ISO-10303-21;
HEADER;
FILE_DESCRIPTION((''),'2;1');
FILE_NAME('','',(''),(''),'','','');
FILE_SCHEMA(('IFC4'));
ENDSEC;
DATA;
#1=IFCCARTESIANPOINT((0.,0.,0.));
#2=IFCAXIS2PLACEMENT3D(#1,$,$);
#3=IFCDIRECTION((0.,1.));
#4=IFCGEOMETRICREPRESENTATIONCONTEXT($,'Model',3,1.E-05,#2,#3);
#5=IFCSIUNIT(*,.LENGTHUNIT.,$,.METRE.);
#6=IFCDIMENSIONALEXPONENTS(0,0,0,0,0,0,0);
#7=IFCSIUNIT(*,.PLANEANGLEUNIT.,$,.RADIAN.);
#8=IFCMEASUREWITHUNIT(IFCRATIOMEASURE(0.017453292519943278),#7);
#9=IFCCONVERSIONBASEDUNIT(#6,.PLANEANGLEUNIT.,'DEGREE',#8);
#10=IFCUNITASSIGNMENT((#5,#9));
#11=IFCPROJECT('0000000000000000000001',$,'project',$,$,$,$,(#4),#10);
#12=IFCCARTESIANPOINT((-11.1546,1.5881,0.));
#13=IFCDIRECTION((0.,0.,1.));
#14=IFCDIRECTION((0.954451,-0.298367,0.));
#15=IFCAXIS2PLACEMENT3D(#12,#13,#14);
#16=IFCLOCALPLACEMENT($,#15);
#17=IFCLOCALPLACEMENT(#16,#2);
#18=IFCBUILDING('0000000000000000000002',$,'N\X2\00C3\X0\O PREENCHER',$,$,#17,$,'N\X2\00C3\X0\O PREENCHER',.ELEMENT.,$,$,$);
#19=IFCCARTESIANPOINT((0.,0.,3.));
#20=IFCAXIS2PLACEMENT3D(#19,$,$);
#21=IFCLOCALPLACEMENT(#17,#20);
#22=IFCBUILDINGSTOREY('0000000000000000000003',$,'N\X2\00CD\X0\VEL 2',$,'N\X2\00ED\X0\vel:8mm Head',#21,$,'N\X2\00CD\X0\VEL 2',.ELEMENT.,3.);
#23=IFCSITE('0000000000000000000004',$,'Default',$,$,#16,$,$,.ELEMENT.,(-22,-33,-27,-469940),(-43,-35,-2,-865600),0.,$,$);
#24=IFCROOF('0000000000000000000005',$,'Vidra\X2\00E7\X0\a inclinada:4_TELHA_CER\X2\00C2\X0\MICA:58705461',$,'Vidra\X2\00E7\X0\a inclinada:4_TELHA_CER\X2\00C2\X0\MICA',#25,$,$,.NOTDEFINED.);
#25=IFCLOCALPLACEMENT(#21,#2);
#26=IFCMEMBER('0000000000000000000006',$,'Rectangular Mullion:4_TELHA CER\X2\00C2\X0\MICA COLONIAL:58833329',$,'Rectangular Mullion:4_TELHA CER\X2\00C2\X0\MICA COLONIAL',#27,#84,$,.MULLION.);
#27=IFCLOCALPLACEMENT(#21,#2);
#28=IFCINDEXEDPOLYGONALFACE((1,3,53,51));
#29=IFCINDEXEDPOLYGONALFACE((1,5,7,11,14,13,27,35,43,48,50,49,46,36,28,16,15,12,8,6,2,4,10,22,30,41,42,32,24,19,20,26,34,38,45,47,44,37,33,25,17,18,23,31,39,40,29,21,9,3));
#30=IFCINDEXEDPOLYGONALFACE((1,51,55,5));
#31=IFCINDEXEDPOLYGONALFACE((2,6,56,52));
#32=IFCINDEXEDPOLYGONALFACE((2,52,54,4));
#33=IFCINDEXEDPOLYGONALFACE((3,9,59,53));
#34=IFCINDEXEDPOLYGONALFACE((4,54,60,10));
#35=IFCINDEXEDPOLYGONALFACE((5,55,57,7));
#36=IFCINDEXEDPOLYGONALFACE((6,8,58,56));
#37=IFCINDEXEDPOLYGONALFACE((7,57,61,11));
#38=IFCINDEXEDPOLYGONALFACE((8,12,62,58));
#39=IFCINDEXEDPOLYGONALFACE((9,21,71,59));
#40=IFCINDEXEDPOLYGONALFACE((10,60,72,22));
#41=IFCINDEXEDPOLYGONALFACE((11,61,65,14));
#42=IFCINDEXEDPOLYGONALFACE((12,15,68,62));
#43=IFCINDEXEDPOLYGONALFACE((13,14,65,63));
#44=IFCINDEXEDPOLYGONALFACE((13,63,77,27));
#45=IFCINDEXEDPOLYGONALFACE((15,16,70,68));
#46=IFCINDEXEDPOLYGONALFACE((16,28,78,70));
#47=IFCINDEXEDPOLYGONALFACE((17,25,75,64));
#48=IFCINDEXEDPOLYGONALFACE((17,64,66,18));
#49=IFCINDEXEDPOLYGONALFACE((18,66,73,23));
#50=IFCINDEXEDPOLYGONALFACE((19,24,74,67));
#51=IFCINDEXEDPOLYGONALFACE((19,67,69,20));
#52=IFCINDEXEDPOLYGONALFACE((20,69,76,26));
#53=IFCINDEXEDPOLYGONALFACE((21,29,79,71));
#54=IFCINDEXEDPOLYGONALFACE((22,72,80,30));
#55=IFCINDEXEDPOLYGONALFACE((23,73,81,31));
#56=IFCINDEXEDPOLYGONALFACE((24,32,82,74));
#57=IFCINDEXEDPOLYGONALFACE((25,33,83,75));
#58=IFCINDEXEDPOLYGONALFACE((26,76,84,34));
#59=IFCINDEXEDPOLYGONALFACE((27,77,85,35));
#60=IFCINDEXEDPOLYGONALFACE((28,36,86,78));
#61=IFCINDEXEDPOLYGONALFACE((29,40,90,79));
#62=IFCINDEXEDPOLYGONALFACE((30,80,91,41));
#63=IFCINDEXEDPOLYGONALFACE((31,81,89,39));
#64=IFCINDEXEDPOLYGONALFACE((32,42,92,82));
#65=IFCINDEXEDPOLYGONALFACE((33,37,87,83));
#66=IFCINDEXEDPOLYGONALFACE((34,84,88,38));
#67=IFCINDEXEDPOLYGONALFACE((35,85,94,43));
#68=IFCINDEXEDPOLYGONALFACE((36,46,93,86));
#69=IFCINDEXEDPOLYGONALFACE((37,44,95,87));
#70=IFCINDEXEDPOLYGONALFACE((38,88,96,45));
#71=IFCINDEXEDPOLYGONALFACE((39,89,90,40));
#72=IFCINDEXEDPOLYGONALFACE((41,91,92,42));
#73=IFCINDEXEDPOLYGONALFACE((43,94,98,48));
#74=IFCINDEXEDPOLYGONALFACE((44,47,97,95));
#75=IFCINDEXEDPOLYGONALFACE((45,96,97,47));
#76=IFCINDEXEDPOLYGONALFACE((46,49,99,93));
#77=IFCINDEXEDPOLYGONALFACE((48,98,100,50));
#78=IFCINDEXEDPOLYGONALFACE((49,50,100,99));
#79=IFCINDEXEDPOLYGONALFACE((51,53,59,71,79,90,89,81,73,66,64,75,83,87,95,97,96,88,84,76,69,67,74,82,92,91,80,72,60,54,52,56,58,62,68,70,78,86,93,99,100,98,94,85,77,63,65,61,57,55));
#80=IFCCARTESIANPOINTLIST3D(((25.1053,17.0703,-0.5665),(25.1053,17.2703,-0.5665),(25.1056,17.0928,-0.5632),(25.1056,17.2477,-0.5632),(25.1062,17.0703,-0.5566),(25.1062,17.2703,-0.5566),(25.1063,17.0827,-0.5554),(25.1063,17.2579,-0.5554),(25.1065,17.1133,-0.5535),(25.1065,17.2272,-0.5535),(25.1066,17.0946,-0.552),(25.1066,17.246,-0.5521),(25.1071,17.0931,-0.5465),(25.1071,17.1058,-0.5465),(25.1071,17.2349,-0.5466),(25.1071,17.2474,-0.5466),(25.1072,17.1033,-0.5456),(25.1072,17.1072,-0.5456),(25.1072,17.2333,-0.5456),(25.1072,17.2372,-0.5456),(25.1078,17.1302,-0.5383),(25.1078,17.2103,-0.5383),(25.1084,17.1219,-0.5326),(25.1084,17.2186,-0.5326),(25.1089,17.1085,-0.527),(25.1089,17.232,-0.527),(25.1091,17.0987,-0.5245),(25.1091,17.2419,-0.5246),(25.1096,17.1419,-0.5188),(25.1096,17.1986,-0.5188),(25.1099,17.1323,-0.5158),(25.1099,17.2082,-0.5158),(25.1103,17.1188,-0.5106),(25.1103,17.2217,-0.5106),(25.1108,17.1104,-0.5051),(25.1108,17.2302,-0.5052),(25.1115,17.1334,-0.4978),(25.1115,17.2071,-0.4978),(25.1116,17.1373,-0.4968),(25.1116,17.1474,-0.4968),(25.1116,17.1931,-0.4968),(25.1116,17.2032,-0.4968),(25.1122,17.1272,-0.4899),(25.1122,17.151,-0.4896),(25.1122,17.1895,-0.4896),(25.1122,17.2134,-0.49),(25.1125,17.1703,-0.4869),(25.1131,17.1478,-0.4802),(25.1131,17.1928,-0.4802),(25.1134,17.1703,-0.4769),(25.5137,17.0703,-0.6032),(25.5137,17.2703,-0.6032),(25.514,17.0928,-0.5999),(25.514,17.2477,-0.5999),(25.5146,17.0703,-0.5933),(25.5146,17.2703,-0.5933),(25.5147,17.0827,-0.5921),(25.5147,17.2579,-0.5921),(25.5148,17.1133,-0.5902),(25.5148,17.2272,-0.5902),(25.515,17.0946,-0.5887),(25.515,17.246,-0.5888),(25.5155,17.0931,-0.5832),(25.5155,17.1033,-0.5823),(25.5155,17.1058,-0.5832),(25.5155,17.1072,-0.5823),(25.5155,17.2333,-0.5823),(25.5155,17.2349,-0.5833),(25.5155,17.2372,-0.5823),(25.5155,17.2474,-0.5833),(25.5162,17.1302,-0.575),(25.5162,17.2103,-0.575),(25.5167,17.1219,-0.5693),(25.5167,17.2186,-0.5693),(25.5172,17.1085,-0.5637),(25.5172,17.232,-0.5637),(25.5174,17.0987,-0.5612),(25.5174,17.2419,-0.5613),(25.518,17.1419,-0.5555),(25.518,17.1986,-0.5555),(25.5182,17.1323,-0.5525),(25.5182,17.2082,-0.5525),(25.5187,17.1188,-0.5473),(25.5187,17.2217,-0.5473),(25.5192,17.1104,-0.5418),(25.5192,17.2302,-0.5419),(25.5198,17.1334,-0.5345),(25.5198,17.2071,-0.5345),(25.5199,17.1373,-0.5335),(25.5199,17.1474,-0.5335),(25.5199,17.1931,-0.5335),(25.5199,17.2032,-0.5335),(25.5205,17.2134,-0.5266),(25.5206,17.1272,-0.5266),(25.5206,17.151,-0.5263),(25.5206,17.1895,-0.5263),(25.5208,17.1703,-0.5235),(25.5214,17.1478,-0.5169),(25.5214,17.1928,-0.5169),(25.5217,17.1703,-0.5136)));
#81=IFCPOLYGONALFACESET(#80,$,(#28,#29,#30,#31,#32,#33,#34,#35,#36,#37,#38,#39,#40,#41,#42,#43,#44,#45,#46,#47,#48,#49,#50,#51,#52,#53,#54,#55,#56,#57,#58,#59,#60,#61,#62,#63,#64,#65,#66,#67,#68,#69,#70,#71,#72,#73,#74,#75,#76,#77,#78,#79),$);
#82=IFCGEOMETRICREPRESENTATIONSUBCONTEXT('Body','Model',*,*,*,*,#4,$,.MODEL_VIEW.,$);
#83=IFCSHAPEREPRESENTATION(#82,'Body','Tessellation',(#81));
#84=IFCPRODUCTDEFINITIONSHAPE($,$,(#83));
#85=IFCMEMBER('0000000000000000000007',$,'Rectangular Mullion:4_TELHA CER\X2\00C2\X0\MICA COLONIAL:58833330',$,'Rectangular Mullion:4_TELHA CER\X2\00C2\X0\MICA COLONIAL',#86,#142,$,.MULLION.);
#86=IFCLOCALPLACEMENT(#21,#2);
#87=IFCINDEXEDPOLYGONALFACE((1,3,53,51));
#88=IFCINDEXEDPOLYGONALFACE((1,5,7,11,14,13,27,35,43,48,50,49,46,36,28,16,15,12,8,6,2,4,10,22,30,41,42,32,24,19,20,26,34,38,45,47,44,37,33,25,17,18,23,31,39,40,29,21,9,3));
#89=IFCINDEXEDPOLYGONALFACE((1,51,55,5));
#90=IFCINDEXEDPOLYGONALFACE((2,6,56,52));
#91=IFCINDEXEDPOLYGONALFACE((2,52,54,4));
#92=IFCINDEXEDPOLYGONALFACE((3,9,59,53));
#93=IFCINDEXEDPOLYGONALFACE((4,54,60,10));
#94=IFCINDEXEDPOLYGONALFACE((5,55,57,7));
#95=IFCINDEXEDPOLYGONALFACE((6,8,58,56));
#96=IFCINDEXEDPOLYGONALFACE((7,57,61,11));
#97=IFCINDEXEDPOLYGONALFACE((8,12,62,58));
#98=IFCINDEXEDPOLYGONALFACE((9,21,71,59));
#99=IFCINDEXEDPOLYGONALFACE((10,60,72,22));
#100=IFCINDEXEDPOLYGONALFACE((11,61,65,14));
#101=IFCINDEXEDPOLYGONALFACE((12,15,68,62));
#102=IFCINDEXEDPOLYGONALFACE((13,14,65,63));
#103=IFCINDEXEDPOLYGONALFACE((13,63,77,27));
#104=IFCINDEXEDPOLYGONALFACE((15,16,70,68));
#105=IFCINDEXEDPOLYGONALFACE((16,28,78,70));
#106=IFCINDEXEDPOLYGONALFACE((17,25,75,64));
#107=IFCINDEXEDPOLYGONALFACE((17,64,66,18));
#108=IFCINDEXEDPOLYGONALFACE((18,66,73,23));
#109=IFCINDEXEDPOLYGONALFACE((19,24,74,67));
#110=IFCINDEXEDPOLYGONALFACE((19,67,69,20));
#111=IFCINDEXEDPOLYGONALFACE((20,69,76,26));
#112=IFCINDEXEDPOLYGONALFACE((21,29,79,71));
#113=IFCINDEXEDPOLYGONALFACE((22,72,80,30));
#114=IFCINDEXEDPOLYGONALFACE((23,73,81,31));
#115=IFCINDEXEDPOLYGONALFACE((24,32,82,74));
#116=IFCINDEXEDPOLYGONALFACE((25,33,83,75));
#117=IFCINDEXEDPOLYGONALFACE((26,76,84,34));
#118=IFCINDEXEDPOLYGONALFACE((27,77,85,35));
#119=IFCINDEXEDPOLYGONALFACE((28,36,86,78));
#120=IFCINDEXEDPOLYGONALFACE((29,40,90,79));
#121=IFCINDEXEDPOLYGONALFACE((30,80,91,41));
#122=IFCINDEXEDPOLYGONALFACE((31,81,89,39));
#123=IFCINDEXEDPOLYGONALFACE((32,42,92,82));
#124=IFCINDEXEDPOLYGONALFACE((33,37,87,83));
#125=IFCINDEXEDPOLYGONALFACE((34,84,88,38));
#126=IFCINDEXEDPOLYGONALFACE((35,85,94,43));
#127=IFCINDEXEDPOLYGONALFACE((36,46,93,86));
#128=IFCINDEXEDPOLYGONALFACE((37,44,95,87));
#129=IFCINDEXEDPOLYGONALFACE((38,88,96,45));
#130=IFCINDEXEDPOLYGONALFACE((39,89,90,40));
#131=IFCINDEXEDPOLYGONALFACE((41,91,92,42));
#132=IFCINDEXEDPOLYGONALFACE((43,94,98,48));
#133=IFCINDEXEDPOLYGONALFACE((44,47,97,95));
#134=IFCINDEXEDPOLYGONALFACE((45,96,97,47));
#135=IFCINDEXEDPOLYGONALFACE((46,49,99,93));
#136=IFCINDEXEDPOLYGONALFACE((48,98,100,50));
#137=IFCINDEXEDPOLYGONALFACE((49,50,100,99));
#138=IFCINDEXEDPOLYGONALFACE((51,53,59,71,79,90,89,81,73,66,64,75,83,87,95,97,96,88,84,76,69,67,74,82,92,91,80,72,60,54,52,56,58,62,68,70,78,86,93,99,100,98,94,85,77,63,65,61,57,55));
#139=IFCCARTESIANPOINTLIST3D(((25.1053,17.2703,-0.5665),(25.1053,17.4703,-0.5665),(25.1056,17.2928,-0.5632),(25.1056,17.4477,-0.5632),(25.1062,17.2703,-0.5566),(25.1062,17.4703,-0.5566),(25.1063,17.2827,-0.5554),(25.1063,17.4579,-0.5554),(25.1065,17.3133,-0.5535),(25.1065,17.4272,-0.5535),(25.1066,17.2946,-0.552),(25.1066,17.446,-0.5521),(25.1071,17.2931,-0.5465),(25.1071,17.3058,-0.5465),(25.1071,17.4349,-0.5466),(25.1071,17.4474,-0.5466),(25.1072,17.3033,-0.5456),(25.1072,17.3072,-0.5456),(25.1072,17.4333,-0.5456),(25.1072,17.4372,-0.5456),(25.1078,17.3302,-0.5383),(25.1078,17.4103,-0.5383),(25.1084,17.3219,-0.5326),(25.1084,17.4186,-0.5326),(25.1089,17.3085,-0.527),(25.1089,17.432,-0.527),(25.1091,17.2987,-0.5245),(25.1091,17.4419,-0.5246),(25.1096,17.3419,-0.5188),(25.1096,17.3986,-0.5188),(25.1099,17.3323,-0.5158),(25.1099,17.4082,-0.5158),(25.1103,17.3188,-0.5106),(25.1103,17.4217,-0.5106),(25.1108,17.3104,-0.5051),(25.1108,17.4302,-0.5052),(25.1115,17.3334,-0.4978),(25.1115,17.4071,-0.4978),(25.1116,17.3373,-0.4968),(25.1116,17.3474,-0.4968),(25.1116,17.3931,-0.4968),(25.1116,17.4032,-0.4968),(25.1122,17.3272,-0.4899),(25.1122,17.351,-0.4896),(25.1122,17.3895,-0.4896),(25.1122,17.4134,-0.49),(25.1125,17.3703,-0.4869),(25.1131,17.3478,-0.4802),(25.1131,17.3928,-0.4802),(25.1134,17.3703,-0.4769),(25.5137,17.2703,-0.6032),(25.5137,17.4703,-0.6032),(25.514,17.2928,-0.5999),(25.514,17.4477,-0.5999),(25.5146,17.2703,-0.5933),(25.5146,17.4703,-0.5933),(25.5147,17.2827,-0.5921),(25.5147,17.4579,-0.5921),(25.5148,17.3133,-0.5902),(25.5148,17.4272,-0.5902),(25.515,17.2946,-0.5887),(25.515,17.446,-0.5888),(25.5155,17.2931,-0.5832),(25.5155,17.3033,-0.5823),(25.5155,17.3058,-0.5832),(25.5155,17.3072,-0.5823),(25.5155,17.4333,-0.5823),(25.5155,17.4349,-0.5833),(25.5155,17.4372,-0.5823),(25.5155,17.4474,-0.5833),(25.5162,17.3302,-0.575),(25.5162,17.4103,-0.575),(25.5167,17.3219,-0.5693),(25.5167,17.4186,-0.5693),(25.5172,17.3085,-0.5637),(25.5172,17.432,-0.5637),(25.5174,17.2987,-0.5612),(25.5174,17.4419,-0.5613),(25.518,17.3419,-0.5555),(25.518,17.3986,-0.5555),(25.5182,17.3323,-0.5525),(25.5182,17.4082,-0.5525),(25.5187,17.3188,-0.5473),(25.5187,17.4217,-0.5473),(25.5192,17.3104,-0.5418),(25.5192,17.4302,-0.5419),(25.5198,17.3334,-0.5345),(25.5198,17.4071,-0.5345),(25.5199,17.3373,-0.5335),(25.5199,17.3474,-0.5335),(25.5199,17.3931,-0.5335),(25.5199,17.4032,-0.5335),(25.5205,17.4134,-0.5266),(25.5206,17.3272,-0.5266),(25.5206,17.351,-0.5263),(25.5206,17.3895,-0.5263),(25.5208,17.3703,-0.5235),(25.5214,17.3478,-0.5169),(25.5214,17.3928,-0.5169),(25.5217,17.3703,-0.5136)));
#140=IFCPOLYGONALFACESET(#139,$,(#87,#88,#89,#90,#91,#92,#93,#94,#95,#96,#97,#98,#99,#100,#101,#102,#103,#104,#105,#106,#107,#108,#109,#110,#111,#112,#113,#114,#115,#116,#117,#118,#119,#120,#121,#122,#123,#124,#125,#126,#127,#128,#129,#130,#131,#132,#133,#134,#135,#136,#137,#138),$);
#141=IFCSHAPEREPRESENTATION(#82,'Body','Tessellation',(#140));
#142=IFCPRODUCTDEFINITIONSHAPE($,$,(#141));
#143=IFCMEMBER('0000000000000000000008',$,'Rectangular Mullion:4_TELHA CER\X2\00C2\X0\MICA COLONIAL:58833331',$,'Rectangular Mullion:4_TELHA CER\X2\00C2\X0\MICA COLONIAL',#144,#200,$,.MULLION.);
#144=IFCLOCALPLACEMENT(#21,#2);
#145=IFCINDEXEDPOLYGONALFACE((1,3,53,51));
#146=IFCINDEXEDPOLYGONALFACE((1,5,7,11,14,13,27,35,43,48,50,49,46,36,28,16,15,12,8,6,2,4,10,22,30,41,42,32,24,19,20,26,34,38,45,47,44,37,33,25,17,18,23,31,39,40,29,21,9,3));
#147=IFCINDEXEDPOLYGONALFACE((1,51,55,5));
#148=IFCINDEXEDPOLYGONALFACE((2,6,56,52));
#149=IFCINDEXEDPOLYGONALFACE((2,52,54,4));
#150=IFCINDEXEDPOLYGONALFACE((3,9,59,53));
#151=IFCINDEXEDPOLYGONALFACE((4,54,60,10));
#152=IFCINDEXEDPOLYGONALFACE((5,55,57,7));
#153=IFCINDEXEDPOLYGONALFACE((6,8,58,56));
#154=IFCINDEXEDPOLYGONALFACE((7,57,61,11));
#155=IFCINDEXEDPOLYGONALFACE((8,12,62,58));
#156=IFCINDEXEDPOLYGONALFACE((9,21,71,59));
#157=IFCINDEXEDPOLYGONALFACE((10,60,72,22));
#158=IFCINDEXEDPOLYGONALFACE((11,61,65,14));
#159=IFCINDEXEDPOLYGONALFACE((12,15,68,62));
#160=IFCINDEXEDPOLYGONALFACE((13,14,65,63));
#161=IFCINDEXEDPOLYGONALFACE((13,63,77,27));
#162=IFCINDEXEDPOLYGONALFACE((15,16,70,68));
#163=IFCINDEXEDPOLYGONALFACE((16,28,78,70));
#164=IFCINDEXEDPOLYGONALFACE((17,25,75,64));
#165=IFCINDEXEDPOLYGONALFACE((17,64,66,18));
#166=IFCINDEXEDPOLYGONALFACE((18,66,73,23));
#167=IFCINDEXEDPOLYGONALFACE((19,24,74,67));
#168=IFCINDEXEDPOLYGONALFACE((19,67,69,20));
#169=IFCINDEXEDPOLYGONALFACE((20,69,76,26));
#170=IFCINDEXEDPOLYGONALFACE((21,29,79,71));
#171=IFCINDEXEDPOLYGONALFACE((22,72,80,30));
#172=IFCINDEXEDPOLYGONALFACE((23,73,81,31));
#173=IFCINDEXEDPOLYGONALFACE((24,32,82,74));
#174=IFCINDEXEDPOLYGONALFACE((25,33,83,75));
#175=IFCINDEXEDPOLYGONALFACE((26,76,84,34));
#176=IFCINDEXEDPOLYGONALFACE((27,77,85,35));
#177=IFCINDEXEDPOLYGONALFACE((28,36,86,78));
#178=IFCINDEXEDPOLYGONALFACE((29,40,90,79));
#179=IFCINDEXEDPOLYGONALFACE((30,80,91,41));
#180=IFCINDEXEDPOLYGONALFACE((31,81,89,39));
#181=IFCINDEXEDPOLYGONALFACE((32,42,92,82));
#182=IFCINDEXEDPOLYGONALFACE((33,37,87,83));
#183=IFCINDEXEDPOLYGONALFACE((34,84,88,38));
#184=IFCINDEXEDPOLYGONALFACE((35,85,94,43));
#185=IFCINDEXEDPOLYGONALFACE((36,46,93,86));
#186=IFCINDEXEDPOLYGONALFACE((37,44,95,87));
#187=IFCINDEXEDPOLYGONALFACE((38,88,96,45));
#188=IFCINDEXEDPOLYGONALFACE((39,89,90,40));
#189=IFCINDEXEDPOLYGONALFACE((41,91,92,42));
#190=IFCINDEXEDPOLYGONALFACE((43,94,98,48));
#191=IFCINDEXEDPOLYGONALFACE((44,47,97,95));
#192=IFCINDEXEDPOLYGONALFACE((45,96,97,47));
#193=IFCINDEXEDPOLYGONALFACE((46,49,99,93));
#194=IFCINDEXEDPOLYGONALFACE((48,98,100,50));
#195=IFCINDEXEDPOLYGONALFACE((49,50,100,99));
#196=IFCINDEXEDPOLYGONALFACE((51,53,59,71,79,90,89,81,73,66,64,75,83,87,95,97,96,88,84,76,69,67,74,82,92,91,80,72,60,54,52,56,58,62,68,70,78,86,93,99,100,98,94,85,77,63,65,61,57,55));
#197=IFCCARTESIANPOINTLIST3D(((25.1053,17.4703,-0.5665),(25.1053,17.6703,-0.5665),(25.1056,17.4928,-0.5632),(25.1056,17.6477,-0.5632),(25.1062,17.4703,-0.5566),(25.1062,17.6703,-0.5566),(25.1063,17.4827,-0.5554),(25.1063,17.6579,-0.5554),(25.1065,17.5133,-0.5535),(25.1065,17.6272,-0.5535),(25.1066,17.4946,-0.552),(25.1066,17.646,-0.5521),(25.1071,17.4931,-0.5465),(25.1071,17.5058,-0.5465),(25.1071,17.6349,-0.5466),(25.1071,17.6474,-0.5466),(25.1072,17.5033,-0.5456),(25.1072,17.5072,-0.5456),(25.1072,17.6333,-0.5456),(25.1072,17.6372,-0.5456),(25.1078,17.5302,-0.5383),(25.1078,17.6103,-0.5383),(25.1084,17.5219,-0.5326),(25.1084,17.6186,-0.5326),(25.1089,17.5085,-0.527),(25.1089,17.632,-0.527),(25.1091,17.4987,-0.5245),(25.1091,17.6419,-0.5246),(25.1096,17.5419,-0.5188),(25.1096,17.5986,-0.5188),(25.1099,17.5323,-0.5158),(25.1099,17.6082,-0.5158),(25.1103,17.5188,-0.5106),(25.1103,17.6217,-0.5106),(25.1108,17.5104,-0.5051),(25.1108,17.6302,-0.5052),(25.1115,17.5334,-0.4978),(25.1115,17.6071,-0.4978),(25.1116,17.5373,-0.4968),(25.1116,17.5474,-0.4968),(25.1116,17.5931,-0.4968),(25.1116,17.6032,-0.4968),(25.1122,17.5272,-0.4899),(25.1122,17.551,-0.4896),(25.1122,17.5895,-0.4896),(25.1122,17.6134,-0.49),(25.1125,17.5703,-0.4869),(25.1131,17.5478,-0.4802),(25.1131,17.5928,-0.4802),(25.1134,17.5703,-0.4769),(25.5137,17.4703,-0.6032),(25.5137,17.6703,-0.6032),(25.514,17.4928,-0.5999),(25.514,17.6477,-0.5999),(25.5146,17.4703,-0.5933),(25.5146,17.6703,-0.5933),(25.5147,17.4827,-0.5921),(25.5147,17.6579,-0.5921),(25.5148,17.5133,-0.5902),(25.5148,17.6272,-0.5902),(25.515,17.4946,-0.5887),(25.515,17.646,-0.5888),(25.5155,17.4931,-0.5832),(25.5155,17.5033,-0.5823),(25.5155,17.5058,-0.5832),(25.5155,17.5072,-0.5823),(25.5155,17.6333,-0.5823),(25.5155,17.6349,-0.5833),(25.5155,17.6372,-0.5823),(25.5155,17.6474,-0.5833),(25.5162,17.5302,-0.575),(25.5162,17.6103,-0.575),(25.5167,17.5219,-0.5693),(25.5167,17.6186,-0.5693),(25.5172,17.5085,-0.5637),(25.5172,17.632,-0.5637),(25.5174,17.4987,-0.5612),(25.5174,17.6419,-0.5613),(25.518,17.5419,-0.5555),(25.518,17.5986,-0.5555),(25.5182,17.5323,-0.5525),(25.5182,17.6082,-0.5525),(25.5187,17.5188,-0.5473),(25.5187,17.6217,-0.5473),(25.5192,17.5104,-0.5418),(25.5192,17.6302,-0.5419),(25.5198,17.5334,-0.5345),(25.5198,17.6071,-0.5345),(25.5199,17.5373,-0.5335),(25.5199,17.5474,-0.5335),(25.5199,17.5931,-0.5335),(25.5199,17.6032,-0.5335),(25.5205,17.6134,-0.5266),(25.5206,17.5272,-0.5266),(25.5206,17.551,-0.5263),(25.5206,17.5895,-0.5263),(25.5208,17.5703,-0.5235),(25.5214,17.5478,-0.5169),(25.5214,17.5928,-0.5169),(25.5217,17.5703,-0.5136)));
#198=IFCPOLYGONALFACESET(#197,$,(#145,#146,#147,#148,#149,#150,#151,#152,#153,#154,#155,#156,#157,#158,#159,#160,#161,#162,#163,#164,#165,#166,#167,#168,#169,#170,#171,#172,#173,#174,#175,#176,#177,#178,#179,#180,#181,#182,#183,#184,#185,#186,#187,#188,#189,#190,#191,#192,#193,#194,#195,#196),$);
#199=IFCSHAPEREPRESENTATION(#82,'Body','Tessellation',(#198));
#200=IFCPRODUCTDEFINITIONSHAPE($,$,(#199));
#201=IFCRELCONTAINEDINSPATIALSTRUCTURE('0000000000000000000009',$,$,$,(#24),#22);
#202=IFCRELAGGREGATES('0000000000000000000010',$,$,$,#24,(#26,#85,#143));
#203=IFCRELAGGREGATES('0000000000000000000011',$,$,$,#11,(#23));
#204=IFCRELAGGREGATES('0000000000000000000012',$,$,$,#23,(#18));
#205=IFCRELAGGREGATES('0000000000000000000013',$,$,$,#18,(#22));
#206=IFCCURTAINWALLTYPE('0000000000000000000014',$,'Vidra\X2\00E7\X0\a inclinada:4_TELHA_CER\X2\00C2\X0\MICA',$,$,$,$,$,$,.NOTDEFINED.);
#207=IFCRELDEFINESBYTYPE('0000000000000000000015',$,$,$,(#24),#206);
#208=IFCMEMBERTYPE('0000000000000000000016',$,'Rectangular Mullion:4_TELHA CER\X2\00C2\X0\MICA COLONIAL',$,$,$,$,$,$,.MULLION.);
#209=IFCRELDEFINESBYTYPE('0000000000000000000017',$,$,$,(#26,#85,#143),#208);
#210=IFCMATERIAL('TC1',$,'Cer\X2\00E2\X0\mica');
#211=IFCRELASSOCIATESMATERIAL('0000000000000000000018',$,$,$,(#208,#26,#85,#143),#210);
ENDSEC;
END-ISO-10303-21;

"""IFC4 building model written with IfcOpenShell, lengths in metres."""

from ifc_helpers import new_model, entity, si_unit, converted_unit, direction, frame, origin, place, context, subcontext, project, spatial, line, arc, indexed_curve, outline, extrude, source, transform, mapped, material, type_object, type_shapes, element, aggregate, save


model = new_model("IFC4")

# Units and contexts
model_context = context("Model", 3, precision=1e-05, world=origin(), true_north=direction((0.0, 1.0)))
body_context = subcontext(model_context, "Body", "Model", "MODEL_VIEW")
ifc_project = project(units=[si_unit("LENGTHUNIT", "METRE"), converted_unit("PLANEANGLEUNIT", "DEGREE", entity("IfcRatioMeasure", 0.017453292519943278), si_unit("PLANEANGLEUNIT", "RADIAN"), dimensions=[0, 0, 0, 0, 0, 0, 0])], contexts=[model_context])

# Site, building, storey
site_placement = place(None, frame((-11.1546, 1.5881, 0.0), z_axis=(0.0, 0.0, 1.0), x_axis=(0.954451, -0.298367, 0.0)))
site = spatial("IfcSite", under=ifc_project, at=site_placement, Name="Default", CompositionType="ELEMENT", RefLatitude=(-22, -33, -27, -469940), RefLongitude=(-43, -35, -2, -865600), RefElevation=0.0)
building_placement = place(site_placement, origin())
building = spatial("IfcBuilding", under=site, at=building_placement, Name="NÃO PREENCHER", LongName="NÃO PREENCHER", CompositionType="ELEMENT")
storey_placement = place(building_placement, frame((0.0, 0.0, 3.0)))
storey = spatial("IfcBuildingStorey", under=building, at=storey_placement, Name="NÍVEL 2", ObjectType="Nível:8mm Head", LongName="NÍVEL 2", CompositionType="ELEMENT", Elevation=3.0)

# Roof, members
curtain_wall_type = type_object("IfcCurtainWallType", Name="Vidraça inclinada:4_TELHA_CERÂMICA", PredefinedType="NOTDEFINED")
roof_placement = place(storey_placement, frame((0.0, 0.0, -3.0)))
roof = element("IfcRoof", 1, at=roof_placement, inside=storey, type_object=curtain_wall_type, Name="Vidraça inclinada:4_TELHA_CERÂMICA:58705461", ObjectType="Vidraça inclinada:4_TELHA_CERÂMICA", PredefinedType="NOTDEFINED")
ifc_material = material(Name="TC1", Category="Cerâmica")
member_type = type_object("IfcMemberType", Name="Rectangular Mullion:4_TELHA CERÂMICA COLONIAL", PredefinedType="MULLION", material=ifc_material)
shared_shape = source(origin(), body_context, "Body", "SweptSolid", [
    extrude(outline(indexed_curve([(-0.029, -0.1), (-0.019, -0.1), (-0.0164, -0.0815), (-0.0089, -0.0645), (-0.0089, -0.0771), (0.061, 0.0), (-0.009, 0.0771), (-0.009, 0.0646), (-0.0165, 0.0816), (-0.019, 0.1), (-0.029, 0.1), (-0.0089, 0.0479), (0.041, 0.0229), (0.041, 0.0329), (0.0131, 0.0425), (-0.008, 0.0631), (-0.008, 0.067), (0.051, 0.0), (-0.008, -0.067), (-0.008, -0.0631), (0.0131, -0.0425), (0.041, -0.0329), (0.041, -0.0229), (-0.0089, -0.0479)], segments=[line(1, 2), arc(2, 3, 4), line(4, 5), arc(5, 6, 7), line(7, 8), arc(8, 9, 10), line(10, 11), arc(11, 12, 13), line(13, 14), arc(14, 15, 16), line(16, 17), arc(17, 18, 19), line(19, 20), arc(20, 21, 22), line(22, 23), arc(23, 24, 1)], self_intersect=False)), frame((0.0, -0.029, -0.41), z_axis=(0.0, 0.0, 1.0), x_axis=(0.0, -1.0, 0.0)), (0.0, 0.0, 1.0), 0.41),
])
type_shapes(member_type, [shared_shape])
member_1_placement = place(roof_placement, frame((25.1053, 17.1703, 2.4335), z_axis=(-0.99599, 0.0, 0.089469), x_axis=(0.0, 1.0, 0.0)))
member_1 = element("IfcMember", 2, at=member_1_placement, type_object=member_type, material=ifc_material, Name="Rectangular Mullion:4_TELHA CERÂMICA COLONIAL:58833329", ObjectType="Rectangular Mullion:4_TELHA CERÂMICA COLONIAL", PredefinedType="MULLION", context=body_context, shape_type="MappedRepresentation", body=[
    mapped(shared_shape, transform((0.0, 0.0, 0.0), scale=1.0)),
])
member_2_placement = place(roof_placement, frame((25.1053, 17.3703, 2.4335), z_axis=(-0.99599, 0.0, 0.089469), x_axis=(0.0, 1.0, 0.0)))
member_2 = element("IfcMember", 3, at=member_2_placement, type_object=member_type, material=ifc_material, Name="Rectangular Mullion:4_TELHA CERÂMICA COLONIAL:58833330", ObjectType="Rectangular Mullion:4_TELHA CERÂMICA COLONIAL", PredefinedType="MULLION", context=body_context, shape_type="MappedRepresentation", body=[
    mapped(shared_shape, transform((0.0, 0.0, 0.0), scale=1.0)),
])
member_3_placement = place(roof_placement, frame((25.1053, 17.5703, 2.4335), z_axis=(-0.99599, 0.0, 0.089469), x_axis=(0.0, 1.0, 0.0)))
member_3 = element("IfcMember", 4, at=member_3_placement, type_object=member_type, material=ifc_material, Name="Rectangular Mullion:4_TELHA CERÂMICA COLONIAL:58833331", ObjectType="Rectangular Mullion:4_TELHA CERÂMICA COLONIAL", PredefinedType="MULLION", context=body_context, shape_type="MappedRepresentation", body=[
    mapped(shared_shape, transform((0.0, 0.0, 0.0), scale=1.0)),
])
aggregate(roof, [member_1, member_2, member_3])

save(model, "model.ifc")
